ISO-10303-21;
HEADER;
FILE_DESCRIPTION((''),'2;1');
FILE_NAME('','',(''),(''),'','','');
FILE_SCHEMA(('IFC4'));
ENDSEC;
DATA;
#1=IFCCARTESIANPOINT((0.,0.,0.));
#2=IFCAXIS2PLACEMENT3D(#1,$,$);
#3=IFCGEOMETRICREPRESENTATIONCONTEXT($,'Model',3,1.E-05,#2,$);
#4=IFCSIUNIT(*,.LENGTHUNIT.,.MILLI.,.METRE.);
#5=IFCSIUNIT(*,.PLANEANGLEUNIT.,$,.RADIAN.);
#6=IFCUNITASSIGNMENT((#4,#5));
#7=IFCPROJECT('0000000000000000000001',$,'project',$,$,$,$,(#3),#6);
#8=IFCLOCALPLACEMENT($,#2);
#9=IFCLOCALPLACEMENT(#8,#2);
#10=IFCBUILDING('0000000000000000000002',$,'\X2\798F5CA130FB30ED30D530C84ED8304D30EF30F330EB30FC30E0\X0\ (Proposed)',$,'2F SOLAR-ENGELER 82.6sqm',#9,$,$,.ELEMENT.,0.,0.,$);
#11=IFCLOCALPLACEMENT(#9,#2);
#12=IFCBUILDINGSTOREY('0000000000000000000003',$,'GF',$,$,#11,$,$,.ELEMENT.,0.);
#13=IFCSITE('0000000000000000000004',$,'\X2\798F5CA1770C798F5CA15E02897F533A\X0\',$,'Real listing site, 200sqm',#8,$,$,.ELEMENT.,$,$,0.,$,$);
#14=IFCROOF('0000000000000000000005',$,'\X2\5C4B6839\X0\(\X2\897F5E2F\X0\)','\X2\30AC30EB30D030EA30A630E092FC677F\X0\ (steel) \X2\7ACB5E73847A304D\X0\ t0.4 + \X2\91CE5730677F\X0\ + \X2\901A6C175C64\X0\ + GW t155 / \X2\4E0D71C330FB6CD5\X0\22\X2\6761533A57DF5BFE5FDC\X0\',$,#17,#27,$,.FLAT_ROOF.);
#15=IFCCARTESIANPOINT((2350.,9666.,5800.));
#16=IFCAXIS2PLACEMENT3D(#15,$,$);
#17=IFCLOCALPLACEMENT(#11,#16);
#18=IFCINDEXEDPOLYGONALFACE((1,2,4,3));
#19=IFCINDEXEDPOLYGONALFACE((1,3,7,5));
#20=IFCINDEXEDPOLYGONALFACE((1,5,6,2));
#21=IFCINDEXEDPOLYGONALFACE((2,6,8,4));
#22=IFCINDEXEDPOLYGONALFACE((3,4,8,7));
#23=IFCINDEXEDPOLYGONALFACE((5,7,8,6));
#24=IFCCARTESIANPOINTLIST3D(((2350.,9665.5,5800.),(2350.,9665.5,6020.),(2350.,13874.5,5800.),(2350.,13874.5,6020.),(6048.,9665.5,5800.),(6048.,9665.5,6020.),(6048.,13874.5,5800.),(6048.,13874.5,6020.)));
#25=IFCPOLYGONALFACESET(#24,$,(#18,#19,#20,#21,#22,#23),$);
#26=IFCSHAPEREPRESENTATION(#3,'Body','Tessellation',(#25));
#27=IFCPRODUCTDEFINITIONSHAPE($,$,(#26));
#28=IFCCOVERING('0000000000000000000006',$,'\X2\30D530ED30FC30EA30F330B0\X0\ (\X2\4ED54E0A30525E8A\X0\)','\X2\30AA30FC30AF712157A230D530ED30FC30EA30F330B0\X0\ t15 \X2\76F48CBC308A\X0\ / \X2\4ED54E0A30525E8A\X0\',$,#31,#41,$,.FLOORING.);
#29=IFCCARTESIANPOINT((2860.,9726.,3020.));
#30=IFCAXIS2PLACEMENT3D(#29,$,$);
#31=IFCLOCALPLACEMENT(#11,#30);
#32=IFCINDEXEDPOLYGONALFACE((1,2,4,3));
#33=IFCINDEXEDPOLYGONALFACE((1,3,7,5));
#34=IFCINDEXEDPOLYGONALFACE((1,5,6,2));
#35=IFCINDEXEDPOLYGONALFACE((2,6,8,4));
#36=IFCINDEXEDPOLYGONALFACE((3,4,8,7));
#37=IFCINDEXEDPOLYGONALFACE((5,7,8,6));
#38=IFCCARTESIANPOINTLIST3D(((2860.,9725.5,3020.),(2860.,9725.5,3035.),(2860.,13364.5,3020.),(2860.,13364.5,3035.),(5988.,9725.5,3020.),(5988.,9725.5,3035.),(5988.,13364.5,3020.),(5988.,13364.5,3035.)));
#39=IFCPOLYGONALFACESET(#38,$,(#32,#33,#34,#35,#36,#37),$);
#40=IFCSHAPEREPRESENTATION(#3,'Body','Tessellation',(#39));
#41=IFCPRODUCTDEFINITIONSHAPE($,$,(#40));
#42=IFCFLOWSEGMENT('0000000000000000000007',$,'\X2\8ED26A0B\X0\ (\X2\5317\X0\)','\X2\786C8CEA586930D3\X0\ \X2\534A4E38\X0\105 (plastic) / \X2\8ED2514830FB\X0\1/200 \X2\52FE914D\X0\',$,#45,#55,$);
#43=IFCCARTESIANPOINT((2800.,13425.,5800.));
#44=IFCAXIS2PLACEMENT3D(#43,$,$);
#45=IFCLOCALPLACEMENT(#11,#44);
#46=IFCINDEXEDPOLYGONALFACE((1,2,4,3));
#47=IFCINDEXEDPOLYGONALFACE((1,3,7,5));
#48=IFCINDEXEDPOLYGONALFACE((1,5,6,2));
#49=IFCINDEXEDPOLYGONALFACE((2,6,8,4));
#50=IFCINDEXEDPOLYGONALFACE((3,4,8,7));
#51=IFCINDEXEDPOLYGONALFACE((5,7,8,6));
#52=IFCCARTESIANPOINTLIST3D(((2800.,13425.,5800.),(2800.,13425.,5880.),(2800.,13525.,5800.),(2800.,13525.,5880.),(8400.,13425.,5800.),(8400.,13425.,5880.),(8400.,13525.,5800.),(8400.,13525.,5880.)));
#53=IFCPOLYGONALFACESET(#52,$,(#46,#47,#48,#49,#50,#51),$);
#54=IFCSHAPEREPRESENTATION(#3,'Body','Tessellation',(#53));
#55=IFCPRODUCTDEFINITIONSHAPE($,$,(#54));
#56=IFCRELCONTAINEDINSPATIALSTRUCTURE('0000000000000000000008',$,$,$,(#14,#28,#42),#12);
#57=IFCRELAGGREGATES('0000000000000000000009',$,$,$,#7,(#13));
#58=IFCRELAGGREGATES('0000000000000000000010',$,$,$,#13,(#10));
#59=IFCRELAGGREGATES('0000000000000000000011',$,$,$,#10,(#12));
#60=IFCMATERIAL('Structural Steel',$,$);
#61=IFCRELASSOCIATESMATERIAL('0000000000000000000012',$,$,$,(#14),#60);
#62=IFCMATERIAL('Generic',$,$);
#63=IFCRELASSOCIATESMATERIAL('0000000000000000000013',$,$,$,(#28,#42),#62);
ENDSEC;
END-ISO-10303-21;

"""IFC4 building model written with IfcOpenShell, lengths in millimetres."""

from ifc_helpers import new_model, si_unit, frame, frame_2d, origin, place, context, project, spatial, rectangle, extrude, material, element, save


model = new_model("IFC4")

# Units and contexts
model_context = context("Model", 3, precision=1e-05, world=origin())
ifc_project = project(units=[si_unit("LENGTHUNIT", "METRE", prefix="MILLI"), si_unit("PLANEANGLEUNIT", "RADIAN")], contexts=[model_context])

# Site, building, storey
site_placement = place(None, origin())
site = spatial("IfcSite", under=ifc_project, at=site_placement, Name="福岡県福岡市西区", ObjectType="Real listing site, 200sqm", CompositionType="ELEMENT", RefElevation=0.0)
building_placement = place(site_placement, origin())
building = spatial("IfcBuilding", under=site, at=building_placement, Name="福岡・ロフト付きワンルーム (Proposed)", ObjectType="2F SOLAR-ENGELER 82.6sqm", CompositionType="ELEMENT", ElevationOfRefHeight=0.0, ElevationOfTerrain=0.0)
storey_placement = place(building_placement, origin())
storey = spatial("IfcBuildingStorey", under=building, at=storey_placement, Name="GF", CompositionType="ELEMENT", Elevation=0.0)

# Roof
ifc_material_1 = material(Name="Structural Steel")
for number, where, name in (
    (1, (2350.0, 9666.0, 5800.0), "屋根(西帯)"),
):
    element("IfcRoof", number, at=place(storey_placement, frame(where)), inside=storey, material=ifc_material_1, Name=name, Description="ガルバリウム鋼板 (steel) 立平葺き t0.4 + 野地板 + 通気層 + GW t155 / 不燃・法22条区域対応", PredefinedType="FLAT_ROOF", context=model_context, shape_type="SweptSolid", body=[
        extrude(rectangle(XDim=3698.0, YDim=4209.0, at=frame_2d((1849.0, 2104.0))), frame((2350.0, 9666.0, 5800.0)), (0.0, 0.0, 1.0), 220.0),
    ])

# Covering
ifc_material_2 = material(Name="Generic")
covering_placement = place(storey_placement, frame((2860.0, 9726.0, 3020.0)))
element("IfcCovering", 2, at=covering_placement, inside=storey, material=ifc_material_2, Name="フローリング (仕上げ床)", Description="オーク無垢フローリング t15 直貼り / 仕上げ床", PredefinedType="FLOORING", context=model_context, shape_type="SweptSolid", body=[
    extrude(rectangle(XDim=3128.0, YDim=3639.0, at=frame_2d((1564.0, 1819.0))), frame((2860.0, 9726.0, 3020.0)), (0.0, 0.0, 1.0), 15.0),
])

# Flow segment
flow_segment_placement = place(storey_placement, frame((2800.0, 13425.0, 5800.0)))
element("IfcFlowSegment", 3, at=flow_segment_placement, inside=storey, material=ifc_material_2, Name="軒樋 (北)", Description="硬質塩ビ 半丸105 (plastic) / 軒先・1/200 勾配", context=model_context, shape_type="SweptSolid", body=[
    extrude(rectangle(XDim=5600.0, YDim=100.0, at=frame_2d((2800.0, 50.0))), frame((2800.0, 13425.0, 5800.0)), (0.0, 0.0, 1.0), 80.0),
])

save(model, "model.ifc")
